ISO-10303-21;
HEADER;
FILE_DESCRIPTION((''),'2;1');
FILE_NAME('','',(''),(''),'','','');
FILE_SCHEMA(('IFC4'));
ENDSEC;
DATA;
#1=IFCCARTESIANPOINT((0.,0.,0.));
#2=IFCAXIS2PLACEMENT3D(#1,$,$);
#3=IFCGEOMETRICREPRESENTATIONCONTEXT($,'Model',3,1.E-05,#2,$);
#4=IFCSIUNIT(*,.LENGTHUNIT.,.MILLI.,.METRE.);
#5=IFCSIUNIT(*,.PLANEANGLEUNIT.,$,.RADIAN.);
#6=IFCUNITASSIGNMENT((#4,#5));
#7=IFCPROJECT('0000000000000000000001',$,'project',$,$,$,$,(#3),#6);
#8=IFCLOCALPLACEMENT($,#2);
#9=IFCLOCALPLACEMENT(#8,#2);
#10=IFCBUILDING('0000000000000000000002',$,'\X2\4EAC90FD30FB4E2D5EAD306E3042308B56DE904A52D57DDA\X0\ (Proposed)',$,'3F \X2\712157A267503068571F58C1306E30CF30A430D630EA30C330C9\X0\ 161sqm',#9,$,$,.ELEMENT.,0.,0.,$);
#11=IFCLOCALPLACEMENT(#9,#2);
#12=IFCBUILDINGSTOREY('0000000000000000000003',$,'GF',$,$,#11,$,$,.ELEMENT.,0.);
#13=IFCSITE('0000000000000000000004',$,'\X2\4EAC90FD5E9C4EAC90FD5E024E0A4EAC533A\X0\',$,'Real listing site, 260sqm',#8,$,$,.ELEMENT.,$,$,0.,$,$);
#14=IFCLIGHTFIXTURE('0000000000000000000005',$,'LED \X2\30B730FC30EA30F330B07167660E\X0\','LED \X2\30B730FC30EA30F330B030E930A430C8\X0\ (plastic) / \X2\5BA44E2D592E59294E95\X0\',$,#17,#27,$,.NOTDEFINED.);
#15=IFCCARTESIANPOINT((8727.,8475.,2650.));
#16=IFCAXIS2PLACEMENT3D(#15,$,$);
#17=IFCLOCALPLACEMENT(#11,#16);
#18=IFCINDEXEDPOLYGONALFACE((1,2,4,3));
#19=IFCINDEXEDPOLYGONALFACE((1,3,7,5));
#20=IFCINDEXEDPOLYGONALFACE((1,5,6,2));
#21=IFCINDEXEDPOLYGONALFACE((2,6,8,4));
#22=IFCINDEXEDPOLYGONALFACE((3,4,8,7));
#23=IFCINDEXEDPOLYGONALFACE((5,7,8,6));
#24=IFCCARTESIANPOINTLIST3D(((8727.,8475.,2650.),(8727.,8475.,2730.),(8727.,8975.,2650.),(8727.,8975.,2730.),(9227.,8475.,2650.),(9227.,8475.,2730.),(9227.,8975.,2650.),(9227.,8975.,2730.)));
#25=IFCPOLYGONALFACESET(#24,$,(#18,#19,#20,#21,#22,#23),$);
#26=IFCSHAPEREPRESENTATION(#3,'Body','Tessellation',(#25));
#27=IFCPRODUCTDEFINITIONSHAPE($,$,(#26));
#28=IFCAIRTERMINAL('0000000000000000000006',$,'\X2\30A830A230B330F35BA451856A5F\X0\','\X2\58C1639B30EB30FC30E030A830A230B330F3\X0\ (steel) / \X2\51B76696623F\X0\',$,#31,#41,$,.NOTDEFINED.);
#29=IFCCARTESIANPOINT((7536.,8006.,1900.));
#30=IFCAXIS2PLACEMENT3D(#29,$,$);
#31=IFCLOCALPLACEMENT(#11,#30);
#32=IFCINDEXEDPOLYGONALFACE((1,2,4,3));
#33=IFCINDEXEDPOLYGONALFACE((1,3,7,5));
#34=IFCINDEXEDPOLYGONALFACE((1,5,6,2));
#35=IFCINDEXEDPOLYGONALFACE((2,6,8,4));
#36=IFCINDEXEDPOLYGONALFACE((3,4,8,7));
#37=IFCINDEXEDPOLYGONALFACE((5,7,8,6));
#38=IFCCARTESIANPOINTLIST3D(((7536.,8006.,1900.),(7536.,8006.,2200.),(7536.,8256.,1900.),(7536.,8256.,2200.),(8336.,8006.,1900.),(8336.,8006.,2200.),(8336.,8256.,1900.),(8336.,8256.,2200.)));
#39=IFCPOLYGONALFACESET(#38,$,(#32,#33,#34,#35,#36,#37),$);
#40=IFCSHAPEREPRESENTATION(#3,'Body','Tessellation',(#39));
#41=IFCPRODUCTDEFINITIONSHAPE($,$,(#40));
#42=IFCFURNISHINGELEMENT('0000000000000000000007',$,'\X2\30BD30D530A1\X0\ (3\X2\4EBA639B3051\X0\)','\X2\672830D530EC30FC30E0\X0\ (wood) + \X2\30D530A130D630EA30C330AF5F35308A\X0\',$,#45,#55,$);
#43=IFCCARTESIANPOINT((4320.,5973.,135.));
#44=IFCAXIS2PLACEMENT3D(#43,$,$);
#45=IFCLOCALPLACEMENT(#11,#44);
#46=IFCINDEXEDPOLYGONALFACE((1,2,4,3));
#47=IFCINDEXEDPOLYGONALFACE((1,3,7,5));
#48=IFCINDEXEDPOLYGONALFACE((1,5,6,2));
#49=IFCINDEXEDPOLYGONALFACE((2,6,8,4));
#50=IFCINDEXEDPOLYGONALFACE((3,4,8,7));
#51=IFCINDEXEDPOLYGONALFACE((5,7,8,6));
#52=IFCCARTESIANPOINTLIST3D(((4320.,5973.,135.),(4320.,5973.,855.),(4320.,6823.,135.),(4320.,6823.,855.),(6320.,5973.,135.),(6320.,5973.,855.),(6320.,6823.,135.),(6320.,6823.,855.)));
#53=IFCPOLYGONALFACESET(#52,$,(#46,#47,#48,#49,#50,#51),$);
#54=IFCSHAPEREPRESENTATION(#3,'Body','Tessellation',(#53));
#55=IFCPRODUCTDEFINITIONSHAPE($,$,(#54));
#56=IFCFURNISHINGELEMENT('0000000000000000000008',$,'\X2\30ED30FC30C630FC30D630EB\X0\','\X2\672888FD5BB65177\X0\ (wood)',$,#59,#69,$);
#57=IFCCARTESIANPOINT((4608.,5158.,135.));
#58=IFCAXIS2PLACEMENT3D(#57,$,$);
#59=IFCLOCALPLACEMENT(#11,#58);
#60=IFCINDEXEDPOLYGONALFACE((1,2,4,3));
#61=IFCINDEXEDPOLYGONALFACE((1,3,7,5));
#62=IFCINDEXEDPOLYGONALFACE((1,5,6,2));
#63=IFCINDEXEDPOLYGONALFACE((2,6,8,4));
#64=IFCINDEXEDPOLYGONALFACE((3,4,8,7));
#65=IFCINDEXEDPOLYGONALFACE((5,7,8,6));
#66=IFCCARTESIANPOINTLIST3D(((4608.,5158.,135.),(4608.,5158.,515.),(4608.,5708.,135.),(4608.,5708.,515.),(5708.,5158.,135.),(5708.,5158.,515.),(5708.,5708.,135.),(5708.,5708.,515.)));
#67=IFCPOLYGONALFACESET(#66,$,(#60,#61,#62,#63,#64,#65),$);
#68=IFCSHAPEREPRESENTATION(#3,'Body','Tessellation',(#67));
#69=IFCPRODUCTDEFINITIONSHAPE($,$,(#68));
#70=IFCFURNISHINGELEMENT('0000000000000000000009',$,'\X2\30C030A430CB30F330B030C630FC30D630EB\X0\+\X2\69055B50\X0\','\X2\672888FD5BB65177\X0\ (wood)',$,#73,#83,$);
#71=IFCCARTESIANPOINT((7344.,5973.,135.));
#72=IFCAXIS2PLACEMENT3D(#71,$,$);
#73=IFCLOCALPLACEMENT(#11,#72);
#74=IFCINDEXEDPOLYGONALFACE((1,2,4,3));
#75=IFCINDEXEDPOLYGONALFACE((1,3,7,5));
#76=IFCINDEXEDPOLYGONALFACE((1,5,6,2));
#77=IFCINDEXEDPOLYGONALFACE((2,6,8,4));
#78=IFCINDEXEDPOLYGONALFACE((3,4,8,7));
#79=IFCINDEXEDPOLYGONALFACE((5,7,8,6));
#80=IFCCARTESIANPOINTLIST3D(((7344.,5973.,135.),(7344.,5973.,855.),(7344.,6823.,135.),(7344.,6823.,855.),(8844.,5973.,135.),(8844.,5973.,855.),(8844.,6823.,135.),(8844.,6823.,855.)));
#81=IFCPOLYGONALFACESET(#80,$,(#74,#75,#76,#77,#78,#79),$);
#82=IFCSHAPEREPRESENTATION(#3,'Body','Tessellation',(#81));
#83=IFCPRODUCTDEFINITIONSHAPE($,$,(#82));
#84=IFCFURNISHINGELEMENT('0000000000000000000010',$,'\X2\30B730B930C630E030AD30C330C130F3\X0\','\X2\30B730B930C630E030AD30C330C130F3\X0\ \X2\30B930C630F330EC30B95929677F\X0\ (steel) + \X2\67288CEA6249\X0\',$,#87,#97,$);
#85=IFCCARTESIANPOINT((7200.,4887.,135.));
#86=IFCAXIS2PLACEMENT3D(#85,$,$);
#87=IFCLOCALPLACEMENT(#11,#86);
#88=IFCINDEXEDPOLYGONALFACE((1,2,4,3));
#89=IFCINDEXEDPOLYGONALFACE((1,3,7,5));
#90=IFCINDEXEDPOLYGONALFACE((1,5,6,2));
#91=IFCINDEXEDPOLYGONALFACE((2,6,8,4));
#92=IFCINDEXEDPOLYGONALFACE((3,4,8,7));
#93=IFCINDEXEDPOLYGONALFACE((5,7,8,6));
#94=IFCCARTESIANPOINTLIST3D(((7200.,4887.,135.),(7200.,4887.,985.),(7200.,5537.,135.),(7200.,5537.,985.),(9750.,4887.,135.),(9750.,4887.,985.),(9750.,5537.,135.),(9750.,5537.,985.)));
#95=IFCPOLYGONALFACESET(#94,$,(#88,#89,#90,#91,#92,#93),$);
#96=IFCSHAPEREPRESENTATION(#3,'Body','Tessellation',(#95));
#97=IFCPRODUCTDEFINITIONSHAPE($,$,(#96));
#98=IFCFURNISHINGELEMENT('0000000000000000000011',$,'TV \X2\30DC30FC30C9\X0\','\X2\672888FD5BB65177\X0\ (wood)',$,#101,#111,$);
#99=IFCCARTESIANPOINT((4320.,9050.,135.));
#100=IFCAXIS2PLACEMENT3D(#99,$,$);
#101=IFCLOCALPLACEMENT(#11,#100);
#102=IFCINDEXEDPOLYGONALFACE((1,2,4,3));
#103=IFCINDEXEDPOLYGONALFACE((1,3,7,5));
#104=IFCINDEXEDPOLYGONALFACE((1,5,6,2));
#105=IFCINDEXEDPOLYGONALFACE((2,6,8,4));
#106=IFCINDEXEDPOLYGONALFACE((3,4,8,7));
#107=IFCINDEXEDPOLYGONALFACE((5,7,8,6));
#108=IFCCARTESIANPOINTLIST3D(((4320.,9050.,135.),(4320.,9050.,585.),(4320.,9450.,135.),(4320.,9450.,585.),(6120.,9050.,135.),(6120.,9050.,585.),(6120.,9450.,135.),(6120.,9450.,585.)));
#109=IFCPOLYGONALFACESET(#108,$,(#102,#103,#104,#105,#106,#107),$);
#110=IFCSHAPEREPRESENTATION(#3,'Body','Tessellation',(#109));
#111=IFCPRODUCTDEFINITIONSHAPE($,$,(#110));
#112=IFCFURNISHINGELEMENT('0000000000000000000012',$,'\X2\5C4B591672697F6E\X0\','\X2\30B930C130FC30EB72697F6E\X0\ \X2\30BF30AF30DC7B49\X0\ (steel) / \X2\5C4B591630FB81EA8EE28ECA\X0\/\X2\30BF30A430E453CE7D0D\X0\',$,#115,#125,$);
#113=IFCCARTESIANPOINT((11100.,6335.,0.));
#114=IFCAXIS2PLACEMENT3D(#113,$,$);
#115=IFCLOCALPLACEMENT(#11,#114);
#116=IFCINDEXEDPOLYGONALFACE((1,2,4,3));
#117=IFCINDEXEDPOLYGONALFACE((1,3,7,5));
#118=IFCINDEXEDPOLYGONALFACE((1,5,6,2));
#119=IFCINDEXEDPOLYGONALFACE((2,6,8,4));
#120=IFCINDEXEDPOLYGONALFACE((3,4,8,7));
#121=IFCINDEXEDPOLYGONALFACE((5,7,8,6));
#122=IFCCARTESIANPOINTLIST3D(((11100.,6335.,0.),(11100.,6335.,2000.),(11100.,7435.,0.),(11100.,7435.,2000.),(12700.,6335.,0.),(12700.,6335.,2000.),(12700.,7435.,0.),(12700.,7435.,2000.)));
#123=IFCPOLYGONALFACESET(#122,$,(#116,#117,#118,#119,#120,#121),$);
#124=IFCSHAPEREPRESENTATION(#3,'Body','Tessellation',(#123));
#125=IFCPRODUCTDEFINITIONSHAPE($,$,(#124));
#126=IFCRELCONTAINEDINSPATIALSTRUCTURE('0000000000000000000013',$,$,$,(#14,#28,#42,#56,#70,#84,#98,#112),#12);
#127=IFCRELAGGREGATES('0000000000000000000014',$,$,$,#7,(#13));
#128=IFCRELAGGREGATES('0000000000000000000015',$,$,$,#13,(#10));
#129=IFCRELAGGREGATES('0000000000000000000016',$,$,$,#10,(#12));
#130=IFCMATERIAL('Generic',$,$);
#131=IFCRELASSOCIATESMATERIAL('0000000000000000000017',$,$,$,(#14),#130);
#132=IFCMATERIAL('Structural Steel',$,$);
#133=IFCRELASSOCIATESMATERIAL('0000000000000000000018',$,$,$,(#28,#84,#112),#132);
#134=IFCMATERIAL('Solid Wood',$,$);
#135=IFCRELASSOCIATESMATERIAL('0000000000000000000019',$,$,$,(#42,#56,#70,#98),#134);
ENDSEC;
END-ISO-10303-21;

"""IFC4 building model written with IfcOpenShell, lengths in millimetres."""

from ifc_helpers import new_model, si_unit, frame, frame_2d, origin, place, context, project, spatial, rectangle, extrude, material, element, save


model = new_model("IFC4")

# Units and contexts
model_context = context("Model", 3, precision=1e-05, world=origin())
ifc_project = project(units=[si_unit("LENGTHUNIT", "METRE", prefix="MILLI"), si_unit("PLANEANGLEUNIT", "RADIAN")], contexts=[model_context])

# Site, building, storey
site_placement = place(None, origin())
site = spatial("IfcSite", under=ifc_project, at=site_placement, Name="京都府京都市上京区", ObjectType="Real listing site, 260sqm", CompositionType="ELEMENT", RefElevation=0.0)
building_placement = place(site_placement, origin())
building = spatial("IfcBuilding", under=site, at=building_placement, Name="京都・中庭のある回遊動線 (Proposed)", ObjectType="3F 無垢材と土壁のハイブリッド 161sqm", CompositionType="ELEMENT", ElevationOfRefHeight=0.0, ElevationOfTerrain=0.0)
storey_placement = place(building_placement, origin())
storey = spatial("IfcBuildingStorey", under=building, at=storey_placement, Name="GF", CompositionType="ELEMENT", Elevation=0.0)

# Shared definitions
ifc_material_1 = material(Name="Solid Wood")

# Shared definitions
ifc_material_2 = material(Name="Structural Steel")

# Shared definitions
ifc_material_3 = material(Name="Generic")

# Light fixture
light_fixture_1_placement = place(storey_placement, frame((8727.0, 8475.0, 2650.0)))
element("IfcLightFixture", 1, at=light_fixture_1_placement, inside=storey, material=ifc_material_3, Name="LED シーリング照明", Description="LED シーリングライト (plastic) / 室中央天井", PredefinedType="NOTDEFINED", context=model_context, shape_type="SweptSolid", body=[
    extrude(rectangle(XDim=500.0, YDim=500.0, at=frame_2d((250.0, 250.0))), frame((8727.0, 8475.0, 2650.0)), (0.0, 0.0, 1.0), 80.0),
])

# Air terminal
air_terminal_1_placement = place(storey_placement, frame((7536.0, 8006.0, 1900.0)))
element("IfcAirTerminal", 2, at=air_terminal_1_placement, inside=storey, material=ifc_material_2, Name="エアコン室内機", Description="壁掛ルームエアコン (steel) / 冷暖房", PredefinedType="NOTDEFINED", context=model_context, shape_type="SweptSolid", body=[
    extrude(rectangle(XDim=800.0, YDim=250.0, at=frame_2d((400.0, 125.0))), frame((7536.0, 8006.0, 1900.0)), (0.0, 0.0, 1.0), 300.0),
])

# Furnishing elements
furnishing_1_placement = place(storey_placement, frame((4320.0, 5973.0, 135.0)))
element("IfcFurnishingElement", 3, at=furnishing_1_placement, inside=storey, material=ifc_material_1, Name="ソファ (3人掛け)", Description="木フレーム (wood) + ファブリック張り", context=model_context, shape_type="SweptSolid", body=[
    extrude(rectangle(XDim=2000.0, YDim=850.0, at=frame_2d((1000.0, 425.0))), frame((4320.0, 5973.0, 135.0)), (0.0, 0.0, 1.0), 720.0),
])
furnishing_2_placement = place(storey_placement, frame((4608.0, 5158.0, 135.0)))
element("IfcFurnishingElement", 4, at=furnishing_2_placement, inside=storey, material=ifc_material_1, Name="ローテーブル", Description="木製家具 (wood)", context=model_context, shape_type="SweptSolid", body=[
    extrude(rectangle(XDim=1100.0, YDim=550.0, at=frame_2d((550.0, 275.0))), frame((4608.0, 5158.0, 135.0)), (0.0, 0.0, 1.0), 380.0),
])
furnishing_3_placement = place(storey_placement, frame((7344.0, 5973.0, 135.0)))
element("IfcFurnishingElement", 5, at=furnishing_3_placement, inside=storey, material=ifc_material_1, Name="ダイニングテーブル+椅子", Description="木製家具 (wood)", context=model_context, shape_type="SweptSolid", body=[
    extrude(rectangle(XDim=1500.0, YDim=850.0, at=frame_2d((750.0, 425.0))), frame((7344.0, 5973.0, 135.0)), (0.0, 0.0, 1.0), 720.0),
])
furnishing_4_placement = place(storey_placement, frame((7200.0, 4887.0, 135.0)))
element("IfcFurnishingElement", 6, at=furnishing_4_placement, inside=storey, material=ifc_material_2, Name="システムキッチン", Description="システムキッチン ステンレス天板 (steel) + 木質扉", context=model_context, shape_type="SweptSolid", body=[
    extrude(rectangle(XDim=2550.0, YDim=650.0, at=frame_2d((1275.0, 325.0))), frame((7200.0, 4887.0, 135.0)), (0.0, 0.0, 1.0), 850.0),
])
furnishing_5_placement = place(storey_placement, frame((4320.0, 9050.0, 135.0)))
element("IfcFurnishingElement", 7, at=furnishing_5_placement, inside=storey, material=ifc_material_1, Name="TV ボード", Description="木製家具 (wood)", context=model_context, shape_type="SweptSolid", body=[
    extrude(rectangle(XDim=1800.0, YDim=400.0, at=frame_2d((900.0, 200.0))), frame((4320.0, 9050.0, 135.0)), (0.0, 0.0, 1.0), 450.0),
])
furnishing_6_placement = place(storey_placement, frame((11100.0, 6335.0, 0.0)))
element("IfcFurnishingElement", 8, at=furnishing_6_placement, inside=storey, material=ifc_material_2, Name="屋外物置", Description="スチール物置 タクボ等 (steel) / 屋外・自転車/タイヤ収納", context=model_context, shape_type="SweptSolid", body=[
    extrude(rectangle(XDim=1600.0, YDim=1100.0, at=frame_2d((800.0, 550.0))), frame((11100.0, 6335.0, 0.0)), (0.0, 0.0, 1.0), 2000.0),
])

save(model, "model.ifc")
